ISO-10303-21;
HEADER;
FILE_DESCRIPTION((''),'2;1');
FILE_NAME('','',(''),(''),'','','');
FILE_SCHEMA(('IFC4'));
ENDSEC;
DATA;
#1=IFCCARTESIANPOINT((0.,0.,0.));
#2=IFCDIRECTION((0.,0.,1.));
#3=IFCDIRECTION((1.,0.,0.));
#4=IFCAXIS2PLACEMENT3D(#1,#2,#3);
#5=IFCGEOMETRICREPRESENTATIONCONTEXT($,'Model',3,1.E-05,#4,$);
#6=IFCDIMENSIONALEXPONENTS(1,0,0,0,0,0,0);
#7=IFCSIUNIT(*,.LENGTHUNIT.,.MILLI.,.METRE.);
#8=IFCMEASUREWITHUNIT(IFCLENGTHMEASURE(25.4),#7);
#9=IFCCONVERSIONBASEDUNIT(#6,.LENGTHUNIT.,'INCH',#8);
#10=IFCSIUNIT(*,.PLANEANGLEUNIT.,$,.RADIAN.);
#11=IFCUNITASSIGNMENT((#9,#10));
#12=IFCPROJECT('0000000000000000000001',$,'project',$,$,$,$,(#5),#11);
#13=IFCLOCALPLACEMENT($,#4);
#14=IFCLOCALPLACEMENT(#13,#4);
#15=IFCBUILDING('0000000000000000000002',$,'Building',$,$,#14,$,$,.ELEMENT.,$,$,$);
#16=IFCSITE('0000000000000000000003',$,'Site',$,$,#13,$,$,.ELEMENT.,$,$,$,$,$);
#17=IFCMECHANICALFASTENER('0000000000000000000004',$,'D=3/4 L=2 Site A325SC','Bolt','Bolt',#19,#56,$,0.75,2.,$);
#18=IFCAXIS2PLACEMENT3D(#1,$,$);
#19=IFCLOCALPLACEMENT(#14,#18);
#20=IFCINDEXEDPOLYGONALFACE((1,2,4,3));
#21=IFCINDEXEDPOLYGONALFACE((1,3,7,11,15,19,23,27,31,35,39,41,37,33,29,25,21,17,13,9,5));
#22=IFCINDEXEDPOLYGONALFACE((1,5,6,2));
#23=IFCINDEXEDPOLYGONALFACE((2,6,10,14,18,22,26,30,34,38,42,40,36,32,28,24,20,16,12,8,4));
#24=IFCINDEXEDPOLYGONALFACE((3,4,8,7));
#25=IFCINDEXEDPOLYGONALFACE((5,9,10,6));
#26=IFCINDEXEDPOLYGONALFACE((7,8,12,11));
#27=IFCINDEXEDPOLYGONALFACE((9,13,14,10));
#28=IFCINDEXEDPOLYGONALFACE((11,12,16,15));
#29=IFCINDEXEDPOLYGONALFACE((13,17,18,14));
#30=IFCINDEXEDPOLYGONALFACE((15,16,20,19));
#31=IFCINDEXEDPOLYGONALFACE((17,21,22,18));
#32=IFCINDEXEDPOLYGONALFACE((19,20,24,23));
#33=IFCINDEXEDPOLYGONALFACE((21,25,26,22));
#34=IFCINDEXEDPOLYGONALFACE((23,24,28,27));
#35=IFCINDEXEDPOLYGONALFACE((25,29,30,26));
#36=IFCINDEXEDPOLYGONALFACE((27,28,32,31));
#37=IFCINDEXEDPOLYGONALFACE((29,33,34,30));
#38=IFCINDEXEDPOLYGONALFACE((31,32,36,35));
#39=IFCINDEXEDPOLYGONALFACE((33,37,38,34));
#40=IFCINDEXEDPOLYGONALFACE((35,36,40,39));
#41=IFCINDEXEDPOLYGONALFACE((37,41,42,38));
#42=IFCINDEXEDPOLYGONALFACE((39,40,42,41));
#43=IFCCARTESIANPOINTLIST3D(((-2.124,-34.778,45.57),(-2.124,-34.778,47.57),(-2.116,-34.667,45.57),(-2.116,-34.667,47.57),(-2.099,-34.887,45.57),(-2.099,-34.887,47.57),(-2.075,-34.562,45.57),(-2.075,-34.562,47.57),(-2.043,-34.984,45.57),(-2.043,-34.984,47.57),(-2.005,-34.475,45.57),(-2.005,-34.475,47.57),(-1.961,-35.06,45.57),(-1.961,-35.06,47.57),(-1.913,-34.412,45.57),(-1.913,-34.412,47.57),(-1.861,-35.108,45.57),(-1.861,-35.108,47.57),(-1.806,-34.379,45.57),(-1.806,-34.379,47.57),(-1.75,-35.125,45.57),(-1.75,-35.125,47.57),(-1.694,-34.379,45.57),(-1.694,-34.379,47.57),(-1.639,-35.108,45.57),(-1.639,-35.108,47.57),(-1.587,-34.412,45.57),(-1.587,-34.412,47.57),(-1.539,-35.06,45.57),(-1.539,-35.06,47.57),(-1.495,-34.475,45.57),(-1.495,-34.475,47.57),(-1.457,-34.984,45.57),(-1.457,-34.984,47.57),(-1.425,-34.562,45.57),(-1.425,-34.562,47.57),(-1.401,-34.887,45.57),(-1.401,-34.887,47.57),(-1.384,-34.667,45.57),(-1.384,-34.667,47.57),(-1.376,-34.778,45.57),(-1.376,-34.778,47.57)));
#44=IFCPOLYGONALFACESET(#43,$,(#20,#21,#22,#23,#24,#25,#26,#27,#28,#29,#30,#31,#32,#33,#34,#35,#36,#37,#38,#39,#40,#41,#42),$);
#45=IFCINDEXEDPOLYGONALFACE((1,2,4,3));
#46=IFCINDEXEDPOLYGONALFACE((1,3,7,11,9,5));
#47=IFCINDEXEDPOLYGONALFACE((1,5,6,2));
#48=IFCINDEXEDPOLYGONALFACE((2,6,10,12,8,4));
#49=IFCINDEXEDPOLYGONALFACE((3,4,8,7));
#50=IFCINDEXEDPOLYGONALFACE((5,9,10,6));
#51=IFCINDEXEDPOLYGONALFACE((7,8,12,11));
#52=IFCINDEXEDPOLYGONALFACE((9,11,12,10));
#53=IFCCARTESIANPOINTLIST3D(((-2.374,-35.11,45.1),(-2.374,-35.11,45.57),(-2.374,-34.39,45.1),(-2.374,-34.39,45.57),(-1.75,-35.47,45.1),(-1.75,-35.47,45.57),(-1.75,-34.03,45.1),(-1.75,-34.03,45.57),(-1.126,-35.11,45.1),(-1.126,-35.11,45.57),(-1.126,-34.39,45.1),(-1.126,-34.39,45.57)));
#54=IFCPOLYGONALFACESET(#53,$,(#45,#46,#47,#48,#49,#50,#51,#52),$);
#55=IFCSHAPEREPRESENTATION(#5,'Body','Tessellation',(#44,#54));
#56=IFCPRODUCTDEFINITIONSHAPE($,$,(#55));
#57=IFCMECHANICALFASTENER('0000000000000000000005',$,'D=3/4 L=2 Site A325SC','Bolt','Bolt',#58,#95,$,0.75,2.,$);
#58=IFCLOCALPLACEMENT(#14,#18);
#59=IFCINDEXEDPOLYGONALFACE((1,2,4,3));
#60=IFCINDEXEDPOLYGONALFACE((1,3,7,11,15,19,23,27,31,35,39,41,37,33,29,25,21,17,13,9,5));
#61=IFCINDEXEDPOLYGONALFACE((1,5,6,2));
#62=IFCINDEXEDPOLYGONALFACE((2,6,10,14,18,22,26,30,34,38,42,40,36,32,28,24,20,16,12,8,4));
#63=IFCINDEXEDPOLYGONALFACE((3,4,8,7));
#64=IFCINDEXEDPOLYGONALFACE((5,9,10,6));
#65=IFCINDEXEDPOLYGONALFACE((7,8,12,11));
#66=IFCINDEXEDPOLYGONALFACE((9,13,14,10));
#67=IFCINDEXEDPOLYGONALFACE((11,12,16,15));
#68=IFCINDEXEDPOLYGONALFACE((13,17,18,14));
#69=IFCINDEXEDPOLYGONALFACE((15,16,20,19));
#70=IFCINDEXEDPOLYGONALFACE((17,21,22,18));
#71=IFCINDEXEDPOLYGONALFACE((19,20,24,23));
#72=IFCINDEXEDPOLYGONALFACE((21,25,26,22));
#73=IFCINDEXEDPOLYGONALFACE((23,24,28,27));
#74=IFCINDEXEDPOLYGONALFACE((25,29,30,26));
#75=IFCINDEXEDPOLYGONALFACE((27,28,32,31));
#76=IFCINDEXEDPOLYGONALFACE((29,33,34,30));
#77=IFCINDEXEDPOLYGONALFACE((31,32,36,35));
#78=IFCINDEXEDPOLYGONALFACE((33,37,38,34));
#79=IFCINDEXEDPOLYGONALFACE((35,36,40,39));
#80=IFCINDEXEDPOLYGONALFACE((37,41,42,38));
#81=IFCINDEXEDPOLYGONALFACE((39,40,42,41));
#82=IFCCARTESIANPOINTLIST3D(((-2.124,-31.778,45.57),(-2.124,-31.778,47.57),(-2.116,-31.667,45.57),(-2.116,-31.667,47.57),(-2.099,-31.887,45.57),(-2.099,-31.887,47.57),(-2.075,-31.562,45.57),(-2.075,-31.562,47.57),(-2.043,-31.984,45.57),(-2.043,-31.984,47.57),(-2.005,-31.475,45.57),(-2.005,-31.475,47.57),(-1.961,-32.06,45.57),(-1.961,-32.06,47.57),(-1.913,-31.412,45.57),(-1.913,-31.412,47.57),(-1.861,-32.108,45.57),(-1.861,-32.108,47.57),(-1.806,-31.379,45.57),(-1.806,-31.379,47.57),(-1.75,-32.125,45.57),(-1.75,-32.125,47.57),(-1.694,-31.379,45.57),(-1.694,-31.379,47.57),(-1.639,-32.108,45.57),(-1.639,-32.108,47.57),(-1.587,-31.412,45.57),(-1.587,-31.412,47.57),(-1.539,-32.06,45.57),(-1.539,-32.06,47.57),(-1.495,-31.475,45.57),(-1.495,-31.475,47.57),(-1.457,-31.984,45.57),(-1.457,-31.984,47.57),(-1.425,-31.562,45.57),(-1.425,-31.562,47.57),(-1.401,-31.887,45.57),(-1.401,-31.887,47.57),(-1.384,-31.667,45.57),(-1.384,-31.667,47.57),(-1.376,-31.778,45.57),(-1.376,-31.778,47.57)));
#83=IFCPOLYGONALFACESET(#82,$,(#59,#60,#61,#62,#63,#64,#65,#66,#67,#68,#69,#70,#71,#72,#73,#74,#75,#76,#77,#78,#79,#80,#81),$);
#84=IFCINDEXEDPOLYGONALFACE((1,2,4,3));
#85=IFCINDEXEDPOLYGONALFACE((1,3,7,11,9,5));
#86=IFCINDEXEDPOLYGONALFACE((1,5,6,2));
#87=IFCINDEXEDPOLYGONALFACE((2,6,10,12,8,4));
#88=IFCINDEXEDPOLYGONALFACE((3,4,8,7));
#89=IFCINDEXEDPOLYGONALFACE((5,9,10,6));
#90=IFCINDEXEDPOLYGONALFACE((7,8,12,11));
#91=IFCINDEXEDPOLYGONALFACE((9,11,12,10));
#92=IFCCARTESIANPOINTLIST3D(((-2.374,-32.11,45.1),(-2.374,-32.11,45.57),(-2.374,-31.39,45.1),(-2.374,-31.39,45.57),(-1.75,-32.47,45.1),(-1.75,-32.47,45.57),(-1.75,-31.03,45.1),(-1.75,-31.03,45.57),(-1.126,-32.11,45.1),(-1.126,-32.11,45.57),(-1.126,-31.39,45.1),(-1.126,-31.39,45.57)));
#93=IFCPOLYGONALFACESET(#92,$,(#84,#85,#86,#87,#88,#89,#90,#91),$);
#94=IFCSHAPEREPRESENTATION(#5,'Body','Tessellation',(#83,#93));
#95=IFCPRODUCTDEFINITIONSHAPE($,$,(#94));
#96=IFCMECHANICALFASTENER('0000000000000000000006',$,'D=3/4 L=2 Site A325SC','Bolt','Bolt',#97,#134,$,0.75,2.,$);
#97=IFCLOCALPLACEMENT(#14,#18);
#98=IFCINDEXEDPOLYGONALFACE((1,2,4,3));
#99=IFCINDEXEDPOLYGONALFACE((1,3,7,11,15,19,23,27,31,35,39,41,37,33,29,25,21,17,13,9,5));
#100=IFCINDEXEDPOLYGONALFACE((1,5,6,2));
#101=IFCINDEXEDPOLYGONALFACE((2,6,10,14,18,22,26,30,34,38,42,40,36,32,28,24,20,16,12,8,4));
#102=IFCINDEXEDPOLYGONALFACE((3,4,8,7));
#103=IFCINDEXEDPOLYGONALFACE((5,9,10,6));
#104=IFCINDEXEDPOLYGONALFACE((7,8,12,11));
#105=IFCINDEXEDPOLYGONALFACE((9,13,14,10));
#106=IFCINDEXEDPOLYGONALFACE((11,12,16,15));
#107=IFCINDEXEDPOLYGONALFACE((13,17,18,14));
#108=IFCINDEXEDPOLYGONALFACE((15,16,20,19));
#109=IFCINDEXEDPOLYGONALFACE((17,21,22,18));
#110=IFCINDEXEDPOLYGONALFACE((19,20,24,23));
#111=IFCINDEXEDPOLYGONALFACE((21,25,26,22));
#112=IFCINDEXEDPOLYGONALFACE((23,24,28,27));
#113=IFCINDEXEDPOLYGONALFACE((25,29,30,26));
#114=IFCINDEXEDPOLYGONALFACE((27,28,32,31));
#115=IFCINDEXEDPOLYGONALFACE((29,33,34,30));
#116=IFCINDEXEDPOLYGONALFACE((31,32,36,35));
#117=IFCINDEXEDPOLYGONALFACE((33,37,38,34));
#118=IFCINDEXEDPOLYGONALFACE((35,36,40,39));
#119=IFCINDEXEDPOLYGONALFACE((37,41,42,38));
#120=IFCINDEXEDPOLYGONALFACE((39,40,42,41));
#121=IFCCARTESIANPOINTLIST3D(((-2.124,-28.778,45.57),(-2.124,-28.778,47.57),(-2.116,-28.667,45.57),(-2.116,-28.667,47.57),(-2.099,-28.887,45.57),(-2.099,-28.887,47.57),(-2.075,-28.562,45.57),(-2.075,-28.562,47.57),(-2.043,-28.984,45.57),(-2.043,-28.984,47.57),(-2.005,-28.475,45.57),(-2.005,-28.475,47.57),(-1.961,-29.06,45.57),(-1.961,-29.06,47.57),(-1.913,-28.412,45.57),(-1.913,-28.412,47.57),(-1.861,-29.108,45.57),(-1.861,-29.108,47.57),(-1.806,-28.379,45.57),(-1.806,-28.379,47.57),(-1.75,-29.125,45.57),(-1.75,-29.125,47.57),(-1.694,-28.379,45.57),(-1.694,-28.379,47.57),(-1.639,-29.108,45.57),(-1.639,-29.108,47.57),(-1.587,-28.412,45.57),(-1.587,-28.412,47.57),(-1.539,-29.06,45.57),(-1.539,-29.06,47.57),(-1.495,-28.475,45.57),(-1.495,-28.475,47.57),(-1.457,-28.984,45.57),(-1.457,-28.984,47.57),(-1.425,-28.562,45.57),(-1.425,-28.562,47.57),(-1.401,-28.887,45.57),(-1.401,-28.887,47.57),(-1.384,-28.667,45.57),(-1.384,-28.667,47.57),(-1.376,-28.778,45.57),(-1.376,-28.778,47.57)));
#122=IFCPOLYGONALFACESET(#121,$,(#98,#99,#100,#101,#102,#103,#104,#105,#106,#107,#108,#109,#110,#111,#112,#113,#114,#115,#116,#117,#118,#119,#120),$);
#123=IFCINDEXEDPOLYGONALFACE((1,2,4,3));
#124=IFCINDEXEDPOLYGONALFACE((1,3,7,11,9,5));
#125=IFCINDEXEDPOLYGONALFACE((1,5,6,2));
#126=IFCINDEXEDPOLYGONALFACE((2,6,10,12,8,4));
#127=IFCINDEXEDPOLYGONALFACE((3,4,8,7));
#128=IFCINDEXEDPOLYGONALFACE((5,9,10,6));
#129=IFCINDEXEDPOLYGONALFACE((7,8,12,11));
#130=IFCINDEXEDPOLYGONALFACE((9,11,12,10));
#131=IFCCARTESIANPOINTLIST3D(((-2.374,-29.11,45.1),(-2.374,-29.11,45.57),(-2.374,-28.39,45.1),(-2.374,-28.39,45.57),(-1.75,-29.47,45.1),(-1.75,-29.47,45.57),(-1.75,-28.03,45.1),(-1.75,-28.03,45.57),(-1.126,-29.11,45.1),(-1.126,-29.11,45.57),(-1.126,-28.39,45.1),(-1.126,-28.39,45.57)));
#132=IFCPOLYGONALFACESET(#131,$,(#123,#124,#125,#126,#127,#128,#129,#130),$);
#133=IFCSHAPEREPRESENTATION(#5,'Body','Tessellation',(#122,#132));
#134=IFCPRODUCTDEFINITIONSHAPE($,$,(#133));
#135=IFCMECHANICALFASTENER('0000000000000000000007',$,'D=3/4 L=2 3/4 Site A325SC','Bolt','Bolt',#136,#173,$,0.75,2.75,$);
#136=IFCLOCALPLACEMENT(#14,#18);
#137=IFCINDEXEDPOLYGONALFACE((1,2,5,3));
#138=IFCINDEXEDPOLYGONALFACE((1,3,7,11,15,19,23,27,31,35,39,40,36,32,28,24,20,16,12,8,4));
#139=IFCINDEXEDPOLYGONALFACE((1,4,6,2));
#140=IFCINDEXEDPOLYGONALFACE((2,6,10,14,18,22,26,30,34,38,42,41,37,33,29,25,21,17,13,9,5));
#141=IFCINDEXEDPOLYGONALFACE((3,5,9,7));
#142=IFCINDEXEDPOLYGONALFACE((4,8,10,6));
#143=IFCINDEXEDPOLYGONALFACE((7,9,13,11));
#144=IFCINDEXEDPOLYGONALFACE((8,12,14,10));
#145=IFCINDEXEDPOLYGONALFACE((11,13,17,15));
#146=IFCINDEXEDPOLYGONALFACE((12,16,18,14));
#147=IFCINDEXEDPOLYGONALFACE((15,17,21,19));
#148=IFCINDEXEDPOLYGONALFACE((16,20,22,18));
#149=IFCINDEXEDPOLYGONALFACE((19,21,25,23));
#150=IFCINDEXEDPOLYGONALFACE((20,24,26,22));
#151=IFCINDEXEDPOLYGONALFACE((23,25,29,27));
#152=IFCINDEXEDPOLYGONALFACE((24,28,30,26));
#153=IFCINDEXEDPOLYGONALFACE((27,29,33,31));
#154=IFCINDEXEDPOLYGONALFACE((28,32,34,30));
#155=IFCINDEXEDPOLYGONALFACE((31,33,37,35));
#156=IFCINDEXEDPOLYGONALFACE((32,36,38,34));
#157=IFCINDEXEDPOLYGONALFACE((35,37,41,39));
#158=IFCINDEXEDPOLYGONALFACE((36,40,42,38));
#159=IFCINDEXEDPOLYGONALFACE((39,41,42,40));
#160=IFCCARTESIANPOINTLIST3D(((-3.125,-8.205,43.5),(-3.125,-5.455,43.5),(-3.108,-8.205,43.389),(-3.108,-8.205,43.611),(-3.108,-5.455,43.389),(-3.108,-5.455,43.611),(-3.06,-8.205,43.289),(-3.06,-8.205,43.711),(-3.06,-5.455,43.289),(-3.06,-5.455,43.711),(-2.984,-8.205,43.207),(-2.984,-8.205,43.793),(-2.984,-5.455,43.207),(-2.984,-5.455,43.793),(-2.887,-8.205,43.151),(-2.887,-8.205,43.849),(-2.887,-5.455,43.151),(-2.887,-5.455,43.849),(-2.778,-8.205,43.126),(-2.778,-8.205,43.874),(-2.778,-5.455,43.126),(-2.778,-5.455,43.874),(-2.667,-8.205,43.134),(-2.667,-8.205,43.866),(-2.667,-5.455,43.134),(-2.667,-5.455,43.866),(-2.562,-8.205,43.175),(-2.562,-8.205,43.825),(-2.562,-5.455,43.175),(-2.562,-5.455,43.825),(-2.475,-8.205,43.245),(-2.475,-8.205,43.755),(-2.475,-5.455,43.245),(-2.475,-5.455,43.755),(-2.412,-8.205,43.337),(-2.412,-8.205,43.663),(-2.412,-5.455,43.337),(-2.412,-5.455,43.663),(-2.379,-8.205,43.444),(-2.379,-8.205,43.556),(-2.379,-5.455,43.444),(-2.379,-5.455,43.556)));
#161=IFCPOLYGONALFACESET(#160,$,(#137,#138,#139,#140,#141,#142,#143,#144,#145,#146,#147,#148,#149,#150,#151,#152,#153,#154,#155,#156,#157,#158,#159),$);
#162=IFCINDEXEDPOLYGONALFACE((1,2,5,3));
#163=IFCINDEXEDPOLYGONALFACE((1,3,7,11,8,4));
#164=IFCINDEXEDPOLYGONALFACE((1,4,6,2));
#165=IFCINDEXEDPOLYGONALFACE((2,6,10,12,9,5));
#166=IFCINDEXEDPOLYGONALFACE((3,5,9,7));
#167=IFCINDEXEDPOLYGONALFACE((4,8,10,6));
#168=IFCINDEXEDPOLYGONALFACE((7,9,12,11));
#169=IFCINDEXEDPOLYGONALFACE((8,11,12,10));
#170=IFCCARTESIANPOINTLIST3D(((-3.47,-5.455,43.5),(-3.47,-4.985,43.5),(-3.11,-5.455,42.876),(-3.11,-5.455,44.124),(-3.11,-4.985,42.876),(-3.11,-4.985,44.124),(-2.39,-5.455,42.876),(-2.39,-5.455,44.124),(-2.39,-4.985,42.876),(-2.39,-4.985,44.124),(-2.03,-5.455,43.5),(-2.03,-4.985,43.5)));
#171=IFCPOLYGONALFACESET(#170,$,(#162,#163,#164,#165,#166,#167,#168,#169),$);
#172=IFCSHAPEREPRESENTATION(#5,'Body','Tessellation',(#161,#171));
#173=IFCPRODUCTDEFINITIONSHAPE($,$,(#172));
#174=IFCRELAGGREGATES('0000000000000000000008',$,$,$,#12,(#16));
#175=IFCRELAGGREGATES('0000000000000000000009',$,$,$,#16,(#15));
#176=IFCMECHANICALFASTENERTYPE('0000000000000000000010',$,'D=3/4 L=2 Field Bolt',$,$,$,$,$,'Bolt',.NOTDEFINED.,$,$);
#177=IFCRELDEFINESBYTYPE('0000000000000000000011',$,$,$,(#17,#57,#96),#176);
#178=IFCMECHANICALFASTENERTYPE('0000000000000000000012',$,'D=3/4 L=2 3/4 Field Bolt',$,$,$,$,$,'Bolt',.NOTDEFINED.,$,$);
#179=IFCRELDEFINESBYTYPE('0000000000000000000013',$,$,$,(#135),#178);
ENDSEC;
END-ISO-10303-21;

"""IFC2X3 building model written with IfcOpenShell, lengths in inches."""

from ifc_helpers import new_model, entity, si_unit, converted_unit, frame, origin_with_axes, origin_2d_with_axis, place, context, project, spatial, polyline, circle, outline, extrude, source, transform, mapped, type_object, type_shapes, element, save


model = new_model("IFC2X3")

# Units and contexts
model_context = context("Model", 3, precision=1e-05, world=origin_with_axes())
ifc_project = project(units=[converted_unit("LENGTHUNIT", "INCH", entity("IfcLengthMeasure", 25.4), si_unit("LENGTHUNIT", "METRE", prefix="MILLI"), dimensions=[1, 0, 0, 0, 0, 0, 0]), si_unit("PLANEANGLEUNIT", "RADIAN")], contexts=[model_context])

# Site, building
site_placement = place(None, origin_with_axes())
site = spatial("IfcSite", under=ifc_project, at=site_placement, Name="Site", CompositionType="ELEMENT")
building_placement = place(site_placement, origin_with_axes())
building = spatial("IfcBuilding", under=site, at=building_placement, Name="Building", CompositionType="ELEMENT")

# Shared definitions
assembly_1_placement = place(building_placement, frame((0.0, 0.0, 46.0), z_axis=(0.0, 0.0, 1.0), x_axis=(0.0, -1.0, 0.0)))

# Mechanical fasteners
mechanical_fastener_type_1 = type_object("IfcMechanicalFastenerType", Name="D=3/4 L=2 Field Bolt", ElementType="Bolt")
shared_shape_1 = source(origin_with_axes(), model_context, "Body", "SweptSolid", [
    extrude(circle(Radius=0.375, at=origin_2d_with_axis()), frame((0.0, 0.0, 0.0), z_axis=(1.0, 0.0, 0.0), x_axis=(0.0, 1.0, 0.0)), (0.0, 0.0, 1.0), 2.0),
    extrude(outline(polyline([(-0.72, 0.0), (-0.36, 0.624), (0.36, 0.624), (0.72, 0.0), (0.36, -0.624), (-0.36, -0.624), (-0.72, 0.0)])), frame((0.0, 0.0, 0.0), z_axis=(1.0, 0.0, 0.0), x_axis=(0.0, 1.0, 0.0)), (0.0, 0.0, -1.0), 0.47),
])
type_shapes(mechanical_fastener_type_1, [shared_shape_1])
placement_1 = place(assembly_1_placement, frame((28.75, -1.75, -0.43), z_axis=(0.0, 1.0, 0.0), x_axis=(0.0, 0.0, 1.0)))
for number, where, z_axis, x_axis, name in (
    (1, (0.0, 6.0, 0.0), (0.0, 0.0, 1.0), (1.0, 0.0, 0.0), "D=3/4 L=2 Site A325SC"),
    (2, (0.0, 3.0, 0.0), (0.0, 0.0, 1.0), (1.0, 0.0, 0.0), "D=3/4 L=2 Site A325SC"),
    (3, (0.0, 0.0, 0.0), (0.0, 0.0, 1.0), (1.0, 0.0, 0.0), "D=3/4 L=2 Site A325SC"),
):
    element("IfcMechanicalFastener", number, at=place(placement_1, frame(where, z_axis=z_axis, x_axis=x_axis)), type_object=mechanical_fastener_type_1, Name=name, Description="Bolt", ObjectType="Bolt", NominalDiameter=0.75, NominalLength=2.0, context=model_context, shape_type="MappedRepresentation", body=[
        mapped(shared_shape_1, transform((0.0, 0.0, 0.0), scale=1.0)),
    ])
mechanical_fastener_type_2 = type_object("IfcMechanicalFastenerType", Name="D=3/4 L=2 3/4 Field Bolt", ElementType="Bolt")
shared_shape_2 = source(origin_with_axes(), model_context, "Body", "SweptSolid", [
    extrude(circle(Radius=0.375, at=origin_2d_with_axis()), frame((0.0, 0.0, 0.0), z_axis=(1.0, 0.0, 0.0), x_axis=(0.0, 1.0, 0.0)), (0.0, 0.0, 1.0), 2.75),
    extrude(outline(polyline([(-0.72, 0.0), (-0.36, 0.624), (0.36, 0.624), (0.72, 0.0), (0.36, -0.624), (-0.36, -0.624), (-0.72, 0.0)])), frame((0.0, 0.0, 0.0), z_axis=(1.0, 0.0, 0.0), x_axis=(0.0, 1.0, 0.0)), (0.0, 0.0, -1.0), 0.47),
])
type_shapes(mechanical_fastener_type_2, [shared_shape_2])
placement_2 = place(assembly_1_placement, frame((5.455, -2.75, 2.0), z_axis=(0.0, 0.0, -1.0), x_axis=(1.0, 0.0, 0.0)))
mechanical_fastener_1_placement = place(placement_2, frame((0.0, 0.0, 4.5), z_axis=(0.0, 0.0, 1.0), x_axis=(1.0, 0.0, 0.0)))
element("IfcMechanicalFastener", 4, at=mechanical_fastener_1_placement, type_object=mechanical_fastener_type_2, Name="D=3/4 L=2 3/4 Site A325SC", Description="Bolt", ObjectType="Bolt", NominalDiameter=0.75, NominalLength=2.75, context=model_context, shape_type="MappedRepresentation", body=[
    mapped(shared_shape_2, transform((0.0, 0.0, 0.0), scale=1.0)),
])

save(model, "model.ifc")
